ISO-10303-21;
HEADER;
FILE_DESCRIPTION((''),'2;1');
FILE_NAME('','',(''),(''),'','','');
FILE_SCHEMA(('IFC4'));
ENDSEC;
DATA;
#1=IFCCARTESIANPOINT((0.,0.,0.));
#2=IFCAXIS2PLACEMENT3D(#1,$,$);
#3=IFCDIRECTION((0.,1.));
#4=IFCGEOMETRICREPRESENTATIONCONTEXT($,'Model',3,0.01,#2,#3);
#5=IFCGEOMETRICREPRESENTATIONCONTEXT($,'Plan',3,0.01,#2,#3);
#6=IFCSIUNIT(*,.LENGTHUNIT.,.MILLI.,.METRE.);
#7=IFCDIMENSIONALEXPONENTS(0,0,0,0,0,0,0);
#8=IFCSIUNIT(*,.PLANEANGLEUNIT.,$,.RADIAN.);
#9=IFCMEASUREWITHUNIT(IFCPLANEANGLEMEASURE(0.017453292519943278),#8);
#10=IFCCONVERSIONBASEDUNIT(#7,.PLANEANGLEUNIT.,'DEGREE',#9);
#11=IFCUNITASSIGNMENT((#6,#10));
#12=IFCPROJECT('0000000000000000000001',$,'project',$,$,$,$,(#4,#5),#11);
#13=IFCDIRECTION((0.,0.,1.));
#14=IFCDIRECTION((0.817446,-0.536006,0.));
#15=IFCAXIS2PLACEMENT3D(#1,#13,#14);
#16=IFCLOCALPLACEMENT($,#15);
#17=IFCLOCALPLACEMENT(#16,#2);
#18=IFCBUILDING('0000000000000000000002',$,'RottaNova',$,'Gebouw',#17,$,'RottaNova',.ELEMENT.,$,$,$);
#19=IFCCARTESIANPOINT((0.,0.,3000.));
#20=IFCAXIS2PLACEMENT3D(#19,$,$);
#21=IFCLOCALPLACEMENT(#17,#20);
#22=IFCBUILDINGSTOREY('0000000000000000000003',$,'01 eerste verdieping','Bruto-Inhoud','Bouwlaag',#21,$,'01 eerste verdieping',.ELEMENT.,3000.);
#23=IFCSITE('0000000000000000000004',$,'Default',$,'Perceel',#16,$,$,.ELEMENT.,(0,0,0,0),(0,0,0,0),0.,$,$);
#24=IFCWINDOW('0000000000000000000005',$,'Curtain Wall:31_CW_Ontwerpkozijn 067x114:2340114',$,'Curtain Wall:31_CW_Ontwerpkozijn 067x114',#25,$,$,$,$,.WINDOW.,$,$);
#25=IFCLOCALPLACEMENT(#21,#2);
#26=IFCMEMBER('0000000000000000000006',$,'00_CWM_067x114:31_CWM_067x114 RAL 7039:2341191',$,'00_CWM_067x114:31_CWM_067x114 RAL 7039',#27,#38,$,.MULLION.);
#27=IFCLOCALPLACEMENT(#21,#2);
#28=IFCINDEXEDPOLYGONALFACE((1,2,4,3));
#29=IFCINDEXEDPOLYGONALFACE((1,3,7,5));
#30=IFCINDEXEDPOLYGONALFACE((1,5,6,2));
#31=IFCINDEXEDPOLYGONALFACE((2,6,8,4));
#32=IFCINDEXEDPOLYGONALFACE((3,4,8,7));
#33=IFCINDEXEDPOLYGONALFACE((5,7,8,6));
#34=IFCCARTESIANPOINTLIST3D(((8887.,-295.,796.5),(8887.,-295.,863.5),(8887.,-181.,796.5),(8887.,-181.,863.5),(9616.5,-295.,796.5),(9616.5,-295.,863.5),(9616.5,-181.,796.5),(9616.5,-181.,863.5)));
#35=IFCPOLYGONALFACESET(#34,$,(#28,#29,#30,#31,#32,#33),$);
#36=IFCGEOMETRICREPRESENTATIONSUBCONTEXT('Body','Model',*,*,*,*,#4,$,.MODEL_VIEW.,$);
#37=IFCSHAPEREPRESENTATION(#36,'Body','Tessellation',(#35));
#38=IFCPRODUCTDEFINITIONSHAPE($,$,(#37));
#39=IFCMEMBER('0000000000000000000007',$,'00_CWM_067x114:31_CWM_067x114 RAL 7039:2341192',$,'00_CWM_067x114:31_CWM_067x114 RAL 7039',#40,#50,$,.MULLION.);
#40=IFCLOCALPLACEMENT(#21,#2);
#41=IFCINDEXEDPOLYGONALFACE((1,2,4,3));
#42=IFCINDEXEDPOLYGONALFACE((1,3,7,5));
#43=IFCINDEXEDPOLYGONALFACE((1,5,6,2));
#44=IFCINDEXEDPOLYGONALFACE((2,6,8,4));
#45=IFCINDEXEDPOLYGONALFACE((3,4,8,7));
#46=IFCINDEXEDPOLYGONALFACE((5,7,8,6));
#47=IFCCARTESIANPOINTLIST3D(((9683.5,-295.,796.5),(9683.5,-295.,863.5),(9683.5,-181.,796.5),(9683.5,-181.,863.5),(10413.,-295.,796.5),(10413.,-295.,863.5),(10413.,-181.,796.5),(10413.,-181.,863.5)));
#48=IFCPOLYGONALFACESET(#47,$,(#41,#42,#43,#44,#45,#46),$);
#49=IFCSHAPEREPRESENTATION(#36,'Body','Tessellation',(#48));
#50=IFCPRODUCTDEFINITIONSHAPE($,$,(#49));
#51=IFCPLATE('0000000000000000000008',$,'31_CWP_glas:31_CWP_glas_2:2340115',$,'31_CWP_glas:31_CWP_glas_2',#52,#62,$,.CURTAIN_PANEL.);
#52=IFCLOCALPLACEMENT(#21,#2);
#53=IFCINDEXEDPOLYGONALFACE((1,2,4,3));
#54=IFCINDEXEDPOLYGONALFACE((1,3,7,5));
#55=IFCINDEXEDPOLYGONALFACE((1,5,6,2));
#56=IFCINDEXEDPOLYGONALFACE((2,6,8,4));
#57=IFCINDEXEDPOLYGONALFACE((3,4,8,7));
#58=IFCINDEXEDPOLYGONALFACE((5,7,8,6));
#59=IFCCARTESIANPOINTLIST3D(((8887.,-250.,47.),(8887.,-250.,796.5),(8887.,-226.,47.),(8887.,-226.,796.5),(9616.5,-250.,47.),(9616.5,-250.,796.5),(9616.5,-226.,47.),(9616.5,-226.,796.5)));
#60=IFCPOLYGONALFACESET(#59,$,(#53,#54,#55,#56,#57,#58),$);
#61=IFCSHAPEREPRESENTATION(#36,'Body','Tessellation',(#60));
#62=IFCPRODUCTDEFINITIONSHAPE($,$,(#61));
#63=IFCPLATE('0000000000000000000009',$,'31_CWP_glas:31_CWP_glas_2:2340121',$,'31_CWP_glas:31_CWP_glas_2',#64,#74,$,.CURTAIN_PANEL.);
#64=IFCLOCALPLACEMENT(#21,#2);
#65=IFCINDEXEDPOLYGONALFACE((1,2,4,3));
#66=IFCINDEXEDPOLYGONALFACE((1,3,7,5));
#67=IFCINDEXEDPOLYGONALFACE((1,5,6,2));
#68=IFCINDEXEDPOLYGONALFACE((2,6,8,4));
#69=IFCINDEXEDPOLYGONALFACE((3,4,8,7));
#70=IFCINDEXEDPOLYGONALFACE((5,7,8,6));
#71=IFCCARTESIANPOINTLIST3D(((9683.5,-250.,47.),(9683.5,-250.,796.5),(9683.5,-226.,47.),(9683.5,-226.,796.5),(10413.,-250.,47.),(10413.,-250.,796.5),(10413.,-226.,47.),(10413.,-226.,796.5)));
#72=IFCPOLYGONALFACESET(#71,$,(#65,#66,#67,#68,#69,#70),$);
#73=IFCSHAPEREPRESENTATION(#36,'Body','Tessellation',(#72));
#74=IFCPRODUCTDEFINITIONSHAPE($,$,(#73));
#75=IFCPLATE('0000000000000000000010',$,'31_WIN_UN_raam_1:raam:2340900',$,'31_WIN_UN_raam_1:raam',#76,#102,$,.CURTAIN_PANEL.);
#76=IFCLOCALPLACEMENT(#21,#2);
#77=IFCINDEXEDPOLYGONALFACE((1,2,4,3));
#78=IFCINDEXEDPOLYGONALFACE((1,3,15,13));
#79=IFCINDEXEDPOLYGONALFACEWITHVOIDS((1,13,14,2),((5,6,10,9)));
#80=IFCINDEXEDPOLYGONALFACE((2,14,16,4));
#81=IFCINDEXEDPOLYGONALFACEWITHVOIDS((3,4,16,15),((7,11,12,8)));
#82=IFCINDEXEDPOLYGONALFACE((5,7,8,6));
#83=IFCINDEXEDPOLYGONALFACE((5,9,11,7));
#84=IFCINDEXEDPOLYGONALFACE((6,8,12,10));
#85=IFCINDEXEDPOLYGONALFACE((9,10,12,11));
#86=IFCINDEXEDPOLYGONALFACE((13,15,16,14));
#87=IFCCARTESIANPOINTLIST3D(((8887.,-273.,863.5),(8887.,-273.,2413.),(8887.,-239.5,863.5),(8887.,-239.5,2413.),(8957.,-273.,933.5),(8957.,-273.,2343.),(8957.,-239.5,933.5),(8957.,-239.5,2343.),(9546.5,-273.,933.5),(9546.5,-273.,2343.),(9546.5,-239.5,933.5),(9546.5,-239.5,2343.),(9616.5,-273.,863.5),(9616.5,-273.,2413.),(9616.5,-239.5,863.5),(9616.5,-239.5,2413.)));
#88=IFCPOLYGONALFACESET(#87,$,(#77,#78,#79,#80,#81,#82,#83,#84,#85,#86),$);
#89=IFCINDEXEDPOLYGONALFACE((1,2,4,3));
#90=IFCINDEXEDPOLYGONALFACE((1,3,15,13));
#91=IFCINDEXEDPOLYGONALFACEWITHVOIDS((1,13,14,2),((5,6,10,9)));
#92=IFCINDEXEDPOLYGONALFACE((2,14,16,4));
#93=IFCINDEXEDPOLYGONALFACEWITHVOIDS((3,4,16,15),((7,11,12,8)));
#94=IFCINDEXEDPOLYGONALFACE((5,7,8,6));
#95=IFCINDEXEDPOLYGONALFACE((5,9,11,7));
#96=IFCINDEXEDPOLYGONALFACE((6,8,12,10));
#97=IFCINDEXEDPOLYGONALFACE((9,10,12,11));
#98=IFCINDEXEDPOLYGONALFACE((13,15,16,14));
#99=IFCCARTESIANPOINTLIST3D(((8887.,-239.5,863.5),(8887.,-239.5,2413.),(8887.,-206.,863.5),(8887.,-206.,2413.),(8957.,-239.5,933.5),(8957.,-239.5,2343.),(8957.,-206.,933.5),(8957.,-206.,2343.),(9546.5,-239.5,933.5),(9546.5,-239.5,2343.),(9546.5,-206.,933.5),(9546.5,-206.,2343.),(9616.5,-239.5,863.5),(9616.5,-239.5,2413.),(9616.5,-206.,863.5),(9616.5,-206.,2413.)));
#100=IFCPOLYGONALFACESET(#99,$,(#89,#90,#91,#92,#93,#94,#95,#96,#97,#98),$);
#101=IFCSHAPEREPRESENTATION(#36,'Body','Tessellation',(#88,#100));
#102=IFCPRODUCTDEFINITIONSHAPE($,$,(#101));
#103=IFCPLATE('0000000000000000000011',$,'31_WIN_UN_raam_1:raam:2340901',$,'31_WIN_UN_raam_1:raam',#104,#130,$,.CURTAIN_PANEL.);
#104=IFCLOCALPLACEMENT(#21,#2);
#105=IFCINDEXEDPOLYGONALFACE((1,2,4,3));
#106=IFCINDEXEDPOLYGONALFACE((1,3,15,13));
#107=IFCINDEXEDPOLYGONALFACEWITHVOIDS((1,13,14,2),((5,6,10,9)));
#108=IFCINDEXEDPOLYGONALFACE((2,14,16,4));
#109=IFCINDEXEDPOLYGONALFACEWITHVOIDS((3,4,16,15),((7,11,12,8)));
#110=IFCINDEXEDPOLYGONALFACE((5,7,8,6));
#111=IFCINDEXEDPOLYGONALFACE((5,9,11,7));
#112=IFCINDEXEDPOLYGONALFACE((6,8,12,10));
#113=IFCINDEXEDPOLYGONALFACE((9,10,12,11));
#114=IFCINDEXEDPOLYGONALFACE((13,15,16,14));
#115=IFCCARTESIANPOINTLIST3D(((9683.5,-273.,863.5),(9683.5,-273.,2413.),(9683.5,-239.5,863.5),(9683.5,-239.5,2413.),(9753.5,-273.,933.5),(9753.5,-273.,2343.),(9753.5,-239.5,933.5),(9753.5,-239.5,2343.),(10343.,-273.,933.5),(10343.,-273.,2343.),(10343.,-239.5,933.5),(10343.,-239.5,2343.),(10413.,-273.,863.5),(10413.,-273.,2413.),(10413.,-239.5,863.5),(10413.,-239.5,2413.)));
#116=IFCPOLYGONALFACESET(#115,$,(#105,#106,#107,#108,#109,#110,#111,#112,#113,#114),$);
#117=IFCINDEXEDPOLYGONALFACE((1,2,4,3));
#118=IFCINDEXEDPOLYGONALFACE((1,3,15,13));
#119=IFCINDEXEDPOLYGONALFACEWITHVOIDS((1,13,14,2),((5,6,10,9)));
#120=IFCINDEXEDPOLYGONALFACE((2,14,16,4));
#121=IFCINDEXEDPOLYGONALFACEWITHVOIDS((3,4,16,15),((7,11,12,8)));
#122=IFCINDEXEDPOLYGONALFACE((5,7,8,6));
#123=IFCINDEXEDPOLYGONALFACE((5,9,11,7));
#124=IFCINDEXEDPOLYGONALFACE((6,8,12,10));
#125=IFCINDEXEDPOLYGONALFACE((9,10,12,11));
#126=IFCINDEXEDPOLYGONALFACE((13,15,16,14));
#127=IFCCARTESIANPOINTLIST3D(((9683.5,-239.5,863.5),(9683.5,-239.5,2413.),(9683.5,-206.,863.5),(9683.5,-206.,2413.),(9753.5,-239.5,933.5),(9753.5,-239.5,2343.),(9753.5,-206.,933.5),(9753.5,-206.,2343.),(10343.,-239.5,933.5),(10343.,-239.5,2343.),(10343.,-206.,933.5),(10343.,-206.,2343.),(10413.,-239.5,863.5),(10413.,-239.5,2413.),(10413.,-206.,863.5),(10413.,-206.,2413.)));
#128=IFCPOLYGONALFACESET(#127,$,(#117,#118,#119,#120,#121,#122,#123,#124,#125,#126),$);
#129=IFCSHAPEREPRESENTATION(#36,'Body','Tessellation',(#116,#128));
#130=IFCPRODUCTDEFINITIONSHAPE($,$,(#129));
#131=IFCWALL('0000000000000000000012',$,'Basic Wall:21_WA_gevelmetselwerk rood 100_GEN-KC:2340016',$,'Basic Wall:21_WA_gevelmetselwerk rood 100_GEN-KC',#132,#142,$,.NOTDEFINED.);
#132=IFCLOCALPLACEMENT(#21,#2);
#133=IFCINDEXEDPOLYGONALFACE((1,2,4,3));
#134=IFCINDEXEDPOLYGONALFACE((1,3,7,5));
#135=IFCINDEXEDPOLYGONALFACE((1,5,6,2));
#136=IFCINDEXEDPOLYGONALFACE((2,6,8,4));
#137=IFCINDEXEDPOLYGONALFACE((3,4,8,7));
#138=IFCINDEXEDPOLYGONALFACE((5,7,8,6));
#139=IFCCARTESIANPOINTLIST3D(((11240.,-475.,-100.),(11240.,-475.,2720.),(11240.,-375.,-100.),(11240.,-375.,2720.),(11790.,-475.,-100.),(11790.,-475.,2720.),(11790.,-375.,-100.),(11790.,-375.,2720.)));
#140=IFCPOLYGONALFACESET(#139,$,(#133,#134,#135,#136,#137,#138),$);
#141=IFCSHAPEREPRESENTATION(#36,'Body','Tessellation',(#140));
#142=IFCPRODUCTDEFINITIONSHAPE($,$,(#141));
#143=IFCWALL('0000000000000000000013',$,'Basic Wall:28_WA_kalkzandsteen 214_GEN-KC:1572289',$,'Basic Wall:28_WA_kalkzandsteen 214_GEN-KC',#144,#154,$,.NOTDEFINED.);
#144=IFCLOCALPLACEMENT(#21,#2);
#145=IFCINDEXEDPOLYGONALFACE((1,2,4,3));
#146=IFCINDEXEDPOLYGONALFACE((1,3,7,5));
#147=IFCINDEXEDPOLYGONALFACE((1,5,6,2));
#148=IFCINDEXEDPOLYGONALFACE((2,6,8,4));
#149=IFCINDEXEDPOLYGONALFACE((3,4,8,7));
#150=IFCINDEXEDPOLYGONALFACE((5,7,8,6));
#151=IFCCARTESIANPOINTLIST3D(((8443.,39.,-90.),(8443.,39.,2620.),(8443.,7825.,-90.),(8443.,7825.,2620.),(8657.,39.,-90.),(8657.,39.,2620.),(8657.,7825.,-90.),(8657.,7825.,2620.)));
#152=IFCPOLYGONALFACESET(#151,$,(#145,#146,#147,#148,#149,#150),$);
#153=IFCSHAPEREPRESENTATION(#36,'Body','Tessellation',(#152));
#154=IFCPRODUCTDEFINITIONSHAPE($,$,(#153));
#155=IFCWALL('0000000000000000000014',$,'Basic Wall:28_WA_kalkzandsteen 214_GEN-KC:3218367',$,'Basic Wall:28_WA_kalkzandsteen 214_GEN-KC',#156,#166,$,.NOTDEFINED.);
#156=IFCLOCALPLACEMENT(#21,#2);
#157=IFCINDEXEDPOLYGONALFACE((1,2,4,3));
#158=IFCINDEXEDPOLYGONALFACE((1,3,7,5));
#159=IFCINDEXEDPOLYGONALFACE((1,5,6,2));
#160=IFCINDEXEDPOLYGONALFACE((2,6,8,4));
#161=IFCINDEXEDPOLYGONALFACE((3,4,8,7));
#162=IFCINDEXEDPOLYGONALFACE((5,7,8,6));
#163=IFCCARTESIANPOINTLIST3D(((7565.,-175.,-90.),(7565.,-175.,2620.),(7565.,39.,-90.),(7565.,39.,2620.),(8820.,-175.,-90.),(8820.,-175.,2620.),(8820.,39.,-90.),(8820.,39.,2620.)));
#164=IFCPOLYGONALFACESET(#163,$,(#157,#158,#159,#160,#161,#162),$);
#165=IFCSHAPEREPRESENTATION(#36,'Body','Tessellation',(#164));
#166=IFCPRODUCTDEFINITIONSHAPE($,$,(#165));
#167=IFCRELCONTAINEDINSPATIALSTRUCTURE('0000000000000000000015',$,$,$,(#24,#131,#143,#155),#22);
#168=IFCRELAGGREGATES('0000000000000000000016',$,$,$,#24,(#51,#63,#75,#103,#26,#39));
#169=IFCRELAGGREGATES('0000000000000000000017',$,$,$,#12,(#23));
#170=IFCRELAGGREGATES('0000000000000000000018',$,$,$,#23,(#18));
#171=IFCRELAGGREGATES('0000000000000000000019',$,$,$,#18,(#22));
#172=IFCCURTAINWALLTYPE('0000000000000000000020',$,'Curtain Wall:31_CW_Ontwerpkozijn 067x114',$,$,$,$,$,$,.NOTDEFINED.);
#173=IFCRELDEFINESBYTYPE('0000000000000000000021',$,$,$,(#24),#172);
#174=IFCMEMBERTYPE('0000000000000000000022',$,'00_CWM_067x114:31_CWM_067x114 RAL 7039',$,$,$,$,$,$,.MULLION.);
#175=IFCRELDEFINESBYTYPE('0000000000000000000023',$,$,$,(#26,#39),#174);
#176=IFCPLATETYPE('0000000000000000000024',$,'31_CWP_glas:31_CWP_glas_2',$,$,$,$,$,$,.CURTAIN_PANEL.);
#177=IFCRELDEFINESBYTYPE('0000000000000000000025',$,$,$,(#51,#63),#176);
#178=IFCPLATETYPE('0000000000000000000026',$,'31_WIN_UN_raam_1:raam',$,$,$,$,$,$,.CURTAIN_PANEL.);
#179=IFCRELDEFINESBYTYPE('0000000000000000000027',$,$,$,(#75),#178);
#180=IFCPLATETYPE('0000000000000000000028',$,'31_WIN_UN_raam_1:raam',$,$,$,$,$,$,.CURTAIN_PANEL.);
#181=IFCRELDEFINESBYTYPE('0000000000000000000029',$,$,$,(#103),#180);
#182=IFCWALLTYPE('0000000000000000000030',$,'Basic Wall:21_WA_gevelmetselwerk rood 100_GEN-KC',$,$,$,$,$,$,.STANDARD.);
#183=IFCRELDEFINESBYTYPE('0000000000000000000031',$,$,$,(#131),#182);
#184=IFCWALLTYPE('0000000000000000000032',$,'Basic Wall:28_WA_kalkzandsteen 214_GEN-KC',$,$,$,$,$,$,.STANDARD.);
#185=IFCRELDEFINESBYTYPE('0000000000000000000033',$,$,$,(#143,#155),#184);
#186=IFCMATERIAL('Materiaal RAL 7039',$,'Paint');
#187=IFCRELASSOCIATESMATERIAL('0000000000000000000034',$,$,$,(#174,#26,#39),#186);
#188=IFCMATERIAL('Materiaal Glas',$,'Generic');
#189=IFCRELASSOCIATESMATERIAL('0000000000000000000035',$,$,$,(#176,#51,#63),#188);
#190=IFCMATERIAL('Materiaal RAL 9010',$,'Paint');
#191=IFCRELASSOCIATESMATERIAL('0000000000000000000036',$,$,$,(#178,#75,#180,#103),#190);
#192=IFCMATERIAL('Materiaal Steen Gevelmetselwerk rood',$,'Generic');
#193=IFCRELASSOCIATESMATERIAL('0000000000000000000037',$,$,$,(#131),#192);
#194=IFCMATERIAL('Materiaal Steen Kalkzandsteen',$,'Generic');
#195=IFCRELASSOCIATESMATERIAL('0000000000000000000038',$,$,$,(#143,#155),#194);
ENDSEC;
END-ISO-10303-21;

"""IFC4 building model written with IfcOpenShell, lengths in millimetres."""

from ifc_helpers import new_model, entity, si_unit, converted_unit, direction, frame, origin, place, context, subcontext, project, spatial, indexed_curve, outline, extrude, source, transform, mapped, material, type_object, type_shapes, element, aggregate, save


model = new_model("IFC4")

# Units and contexts
model_context = context("Model", 3, precision=0.01, world=origin(), true_north=direction((0.0, 1.0)))
plan_context = context("Plan", 3, precision=0.01, world=origin(), true_north=direction((0.0, 1.0)))
body_context = subcontext(model_context, "Body", "Model", "MODEL_VIEW")
ifc_project = project(units=[si_unit("LENGTHUNIT", "METRE", prefix="MILLI"), converted_unit("PLANEANGLEUNIT", "DEGREE", entity("IfcPlaneAngleMeasure", 0.017453292519943278), si_unit("PLANEANGLEUNIT", "RADIAN"), dimensions=[0, 0, 0, 0, 0, 0, 0])], contexts=[model_context, plan_context])

# Site, building, storey
site_placement = place(None, frame((0.0, 0.0, 0.0), z_axis=(0.0, 0.0, 1.0), x_axis=(0.817446, -0.536006, 0.0)))
site = spatial("IfcSite", under=ifc_project, at=site_placement, Name="Default", ObjectType="Perceel", CompositionType="ELEMENT", RefLatitude=(0, 0, 0, 0), RefLongitude=(0, 0, 0, 0), RefElevation=0.0)
building_placement = place(site_placement, origin())
building = spatial("IfcBuilding", under=site, at=building_placement, Name="RottaNova", ObjectType="Gebouw", LongName="RottaNova", CompositionType="ELEMENT")
storey_placement = place(building_placement, frame((0.0, 0.0, 3000.0)))
storey = spatial("IfcBuildingStorey", under=building, at=storey_placement, Name="01 eerste verdieping", Description="Bruto-Inhoud", ObjectType="Bouwlaag", LongName="01 eerste verdieping", CompositionType="ELEMENT", Elevation=3000.0)

# Window, members, plates
curtain_wall_type = type_object("IfcCurtainWallType", Name="Curtain Wall:31_CW_Ontwerpkozijn 067x114", PredefinedType="NOTDEFINED")
window_placement = place(storey_placement, frame((0.0, 0.0, -3000.0)))
window = element("IfcWindow", 1, at=window_placement, inside=storey, type_object=curtain_wall_type, Name="Curtain Wall:31_CW_Ontwerpkozijn 067x114:2340114", ObjectType="Curtain Wall:31_CW_Ontwerpkozijn 067x114", PredefinedType="WINDOW")
ifc_material_1 = material(Name="Materiaal RAL 7039", Category="Paint")
member_type_1 = type_object("IfcMemberType", Name="00_CWM_067x114:31_CWM_067x114 RAL 7039", PredefinedType="MULLION", material=ifc_material_1)
shared_shape_1 = source(origin(), body_context, "Body", "SweptSolid", [
    extrude(outline(indexed_curve([(-33.5, -57.0), (33.5, -57.0), (33.5, 57.0), (-33.5, 57.0), (-33.5, -57.0)], self_intersect=False)), frame((0.0, 57.0, -729.5), z_axis=(0.0, 0.0, 1.0), x_axis=(-1.0, 0.0, 0.0)), (0.0, 0.0, 1.0), 729.5),
])
type_shapes(member_type_1, [shared_shape_1])
member_1_placement = place(window_placement, frame((9616.5, -181.0, 3830.0), z_axis=(1.0, 0.0, 0.0), x_axis=(0.0, 0.0, 1.0)))
member_1 = element("IfcMember", 2, at=member_1_placement, type_object=member_type_1, material=ifc_material_1, Name="00_CWM_067x114:31_CWM_067x114 RAL 7039:2341191", ObjectType="00_CWM_067x114:31_CWM_067x114 RAL 7039", PredefinedType="MULLION", context=body_context, shape_type="MappedRepresentation", body=[
    mapped(shared_shape_1, transform((0.0, 0.0, 0.0), scale=1.0)),
])
member_2_placement = place(window_placement, frame((10413.0, -181.0, 3830.0), z_axis=(1.0, 0.0, 0.0), x_axis=(0.0, 0.0, 1.0)))
member_2 = element("IfcMember", 3, at=member_2_placement, type_object=member_type_1, material=ifc_material_1, Name="00_CWM_067x114:31_CWM_067x114 RAL 7039:2341192", ObjectType="00_CWM_067x114:31_CWM_067x114 RAL 7039", PredefinedType="MULLION", context=body_context, shape_type="MappedRepresentation", body=[
    mapped(shared_shape_1, transform((0.0, 0.0, 0.0), scale=1.0)),
])
ifc_material_2 = material(Name="Materiaal Glas", Category="Generic")
plate_type_1 = type_object("IfcPlateType", Name="31_CWP_glas:31_CWP_glas_2", PredefinedType="CURTAIN_PANEL", material=ifc_material_2)
shared_shape_2 = source(origin(), body_context, "Body", "SweptSolid", [
    extrude(outline(indexed_curve([(-12.0, -364.7), (12.0, -364.7), (12.0, 364.7), (-12.0, 364.7), (-12.0, -364.7)], self_intersect=False)), frame((0.0, -57.0, 0.0), z_axis=(0.0, 0.0, 1.0), x_axis=(0.0, 1.0, 0.0)), (0.0, 0.0, 1.0), 749.5),
])
type_shapes(plate_type_1, [shared_shape_2])
plate_1_placement = place(window_placement, frame((9251.7, -181.0, 3047.0)))
plate_1 = element("IfcPlate", 4, at=plate_1_placement, type_object=plate_type_1, material=ifc_material_2, Name="31_CWP_glas:31_CWP_glas_2:2340115", ObjectType="31_CWP_glas:31_CWP_glas_2", PredefinedType="CURTAIN_PANEL", context=body_context, shape_type="MappedRepresentation", body=[
    mapped(shared_shape_2, transform((0.0, 0.0, 0.0), scale=1.0)),
])
plate_2_placement = place(window_placement, frame((10048.2, -181.0, 3047.0)))
plate_2 = element("IfcPlate", 5, at=plate_2_placement, type_object=plate_type_1, material=ifc_material_2, Name="31_CWP_glas:31_CWP_glas_2:2340121", ObjectType="31_CWP_glas:31_CWP_glas_2", PredefinedType="CURTAIN_PANEL", context=body_context, shape_type="MappedRepresentation", body=[
    mapped(shared_shape_2, transform((0.0, 0.0, 0.0), scale=1.0)),
])
ifc_material_3 = material(Name="Materiaal RAL 9010", Category="Paint")
plate_type_2 = type_object("IfcPlateType", Name="31_WIN_UN_raam_1:raam", PredefinedType="CURTAIN_PANEL", material=ifc_material_3)
shared_shape_3 = source(origin(), body_context, "Body", "SweptSolid", [
    extrude(outline(indexed_curve([(-364.7, -774.7), (364.7, -774.7), (364.7, 774.7), (-364.7, 774.7), (-364.7, -774.7)], self_intersect=False), holes=[indexed_curve([(-294.7, 704.7), (294.7, 704.7), (294.7, -704.8), (-294.7, -704.8), (-294.7, 704.7)], self_intersect=False)]), frame((0.0, -92.0, 774.8), z_axis=(0.0, 1.0, 0.0), x_axis=(1.0, 0.0, 0.0)), (0.0, 0.0, 1.0), 33.5),
    extrude(outline(indexed_curve([(-364.7, -774.7), (364.7, -774.7), (364.7, 774.7), (-364.7, 774.7), (-364.7, -774.7)], self_intersect=False), holes=[indexed_curve([(-294.7, 704.7), (294.7, 704.7), (294.7, -704.8), (-294.7, -704.8), (-294.7, 704.7)], self_intersect=False)]), frame((0.0, -58.5, 774.8), z_axis=(0.0, 1.0, 0.0), x_axis=(1.0, 0.0, 0.0)), (0.0, 0.0, 1.0), 33.5),
])
type_shapes(plate_type_2, [shared_shape_3])
plate_3_placement = place(window_placement, frame((9251.7, -181.0, 3863.5)))
plate_3 = element("IfcPlate", 6, at=plate_3_placement, type_object=plate_type_2, material=ifc_material_3, Name="31_WIN_UN_raam_1:raam:2340900", ObjectType="31_WIN_UN_raam_1:raam", PredefinedType="CURTAIN_PANEL", context=body_context, shape_type="MappedRepresentation", body=[
    mapped(shared_shape_3, transform((0.0, 0.0, 0.0), scale=1.0)),
])
plate_type_3 = type_object("IfcPlateType", Name="31_WIN_UN_raam_1:raam", PredefinedType="CURTAIN_PANEL", material=ifc_material_3)
shared_shape_4 = source(origin(), body_context, "Body", "SweptSolid", [
    extrude(outline(indexed_curve([(-364.7, -774.7), (364.7, -774.7), (364.7, 774.7), (-364.7, 774.7), (-364.7, -774.7)], self_intersect=False), holes=[indexed_curve([(-294.7, 704.7), (294.7, 704.7), (294.7, -704.8), (-294.7, -704.8), (-294.7, 704.7)], self_intersect=False)]), frame((0.0, -92.0, 774.8), z_axis=(0.0, 1.0, 0.0), x_axis=(1.0, 0.0, 0.0)), (0.0, 0.0, 1.0), 33.5),
    extrude(outline(indexed_curve([(-364.7, -774.7), (364.7, -774.7), (364.7, 774.7), (-364.7, 774.7), (-364.7, -774.7)], self_intersect=False), holes=[indexed_curve([(-294.7, 704.7), (294.7, 704.7), (294.7, -704.8), (-294.7, -704.8), (-294.7, 704.7)], self_intersect=False)]), frame((0.0, -58.5, 774.8), z_axis=(0.0, 1.0, 0.0), x_axis=(1.0, 0.0, 0.0)), (0.0, 0.0, 1.0), 33.5),
])
type_shapes(plate_type_3, [shared_shape_4])
plate_4_placement = place(window_placement, frame((10048.2, -181.0, 3863.5)))
plate_4 = element("IfcPlate", 7, at=plate_4_placement, type_object=plate_type_3, material=ifc_material_3, Name="31_WIN_UN_raam_1:raam:2340901", ObjectType="31_WIN_UN_raam_1:raam", PredefinedType="CURTAIN_PANEL", context=body_context, shape_type="MappedRepresentation", body=[
    mapped(shared_shape_4, transform((0.0, 0.0, 0.0), scale=1.0)),
])
aggregate(window, [plate_1, plate_2, plate_3, plate_4, member_1, member_2])

# Walls
ifc_material_4 = material(Name="Materiaal Steen Gevelmetselwerk rood", Category="Generic")
wall_type_1 = type_object("IfcWallType", Name="Basic Wall:21_WA_gevelmetselwerk rood 100_GEN-KC", PredefinedType="STANDARD")
wall_1_placement = place(storey_placement, frame((11240.0, -425.0, -100.0)))
element("IfcWall", 8, at=wall_1_placement, inside=storey, type_object=wall_type_1, material=ifc_material_4, Name="Basic Wall:21_WA_gevelmetselwerk rood 100_GEN-KC:2340016", ObjectType="Basic Wall:21_WA_gevelmetselwerk rood 100_GEN-KC", PredefinedType="NOTDEFINED", context=body_context, shape_type="SweptSolid", body=[
    extrude(outline(indexed_curve([(550.0, 50.0), (0.0, 50.0), (0.0, -50.0), (550.0, -50.0), (550.0, 50.0)], self_intersect=False)), origin(), (0.0, 0.0, 1.0), 2820.0),
])
ifc_material_5 = material(Name="Materiaal Steen Kalkzandsteen", Category="Generic")
wall_type_2 = type_object("IfcWallType", Name="Basic Wall:28_WA_kalkzandsteen 214_GEN-KC", PredefinedType="STANDARD")
wall_2_placement = place(storey_placement, frame((8550.0, 39.0, -90.0), z_axis=(0.0, 0.0, 1.0), x_axis=(0.0, 1.0, 0.0)))
element("IfcWall", 9, at=wall_2_placement, inside=storey, type_object=wall_type_2, material=ifc_material_5, Name="Basic Wall:28_WA_kalkzandsteen 214_GEN-KC:1572289", ObjectType="Basic Wall:28_WA_kalkzandsteen 214_GEN-KC", PredefinedType="NOTDEFINED", context=body_context, shape_type="SweptSolid", body=[
    extrude(outline(indexed_curve([(-3893.0, -107.0), (3893.0, -107.0), (3893.0, 107.0), (-3893.0, 107.0), (-3893.0, -107.0)], self_intersect=False)), frame((3893.0, 0.0, 0.0)), (0.0, 0.0, 1.0), 2710.0),
])
wall_3_placement = place(storey_placement, frame((8820.0, -68.0, -90.0), z_axis=(0.0, 0.0, 1.0), x_axis=(-1.0, 0.0, 0.0)))
element("IfcWall", 10, at=wall_3_placement, inside=storey, type_object=wall_type_2, material=ifc_material_5, Name="Basic Wall:28_WA_kalkzandsteen 214_GEN-KC:3218367", ObjectType="Basic Wall:28_WA_kalkzandsteen 214_GEN-KC", PredefinedType="NOTDEFINED", context=body_context, shape_type="SweptSolid", body=[
    extrude(outline(indexed_curve([(1255.0, 107.0), (0.0, 107.0), (0.0, -107.0), (1255.0, -107.0), (1255.0, 107.0)], self_intersect=False)), origin(), (0.0, 0.0, 1.0), 2710.0),
])

save(model, "model.ifc")
